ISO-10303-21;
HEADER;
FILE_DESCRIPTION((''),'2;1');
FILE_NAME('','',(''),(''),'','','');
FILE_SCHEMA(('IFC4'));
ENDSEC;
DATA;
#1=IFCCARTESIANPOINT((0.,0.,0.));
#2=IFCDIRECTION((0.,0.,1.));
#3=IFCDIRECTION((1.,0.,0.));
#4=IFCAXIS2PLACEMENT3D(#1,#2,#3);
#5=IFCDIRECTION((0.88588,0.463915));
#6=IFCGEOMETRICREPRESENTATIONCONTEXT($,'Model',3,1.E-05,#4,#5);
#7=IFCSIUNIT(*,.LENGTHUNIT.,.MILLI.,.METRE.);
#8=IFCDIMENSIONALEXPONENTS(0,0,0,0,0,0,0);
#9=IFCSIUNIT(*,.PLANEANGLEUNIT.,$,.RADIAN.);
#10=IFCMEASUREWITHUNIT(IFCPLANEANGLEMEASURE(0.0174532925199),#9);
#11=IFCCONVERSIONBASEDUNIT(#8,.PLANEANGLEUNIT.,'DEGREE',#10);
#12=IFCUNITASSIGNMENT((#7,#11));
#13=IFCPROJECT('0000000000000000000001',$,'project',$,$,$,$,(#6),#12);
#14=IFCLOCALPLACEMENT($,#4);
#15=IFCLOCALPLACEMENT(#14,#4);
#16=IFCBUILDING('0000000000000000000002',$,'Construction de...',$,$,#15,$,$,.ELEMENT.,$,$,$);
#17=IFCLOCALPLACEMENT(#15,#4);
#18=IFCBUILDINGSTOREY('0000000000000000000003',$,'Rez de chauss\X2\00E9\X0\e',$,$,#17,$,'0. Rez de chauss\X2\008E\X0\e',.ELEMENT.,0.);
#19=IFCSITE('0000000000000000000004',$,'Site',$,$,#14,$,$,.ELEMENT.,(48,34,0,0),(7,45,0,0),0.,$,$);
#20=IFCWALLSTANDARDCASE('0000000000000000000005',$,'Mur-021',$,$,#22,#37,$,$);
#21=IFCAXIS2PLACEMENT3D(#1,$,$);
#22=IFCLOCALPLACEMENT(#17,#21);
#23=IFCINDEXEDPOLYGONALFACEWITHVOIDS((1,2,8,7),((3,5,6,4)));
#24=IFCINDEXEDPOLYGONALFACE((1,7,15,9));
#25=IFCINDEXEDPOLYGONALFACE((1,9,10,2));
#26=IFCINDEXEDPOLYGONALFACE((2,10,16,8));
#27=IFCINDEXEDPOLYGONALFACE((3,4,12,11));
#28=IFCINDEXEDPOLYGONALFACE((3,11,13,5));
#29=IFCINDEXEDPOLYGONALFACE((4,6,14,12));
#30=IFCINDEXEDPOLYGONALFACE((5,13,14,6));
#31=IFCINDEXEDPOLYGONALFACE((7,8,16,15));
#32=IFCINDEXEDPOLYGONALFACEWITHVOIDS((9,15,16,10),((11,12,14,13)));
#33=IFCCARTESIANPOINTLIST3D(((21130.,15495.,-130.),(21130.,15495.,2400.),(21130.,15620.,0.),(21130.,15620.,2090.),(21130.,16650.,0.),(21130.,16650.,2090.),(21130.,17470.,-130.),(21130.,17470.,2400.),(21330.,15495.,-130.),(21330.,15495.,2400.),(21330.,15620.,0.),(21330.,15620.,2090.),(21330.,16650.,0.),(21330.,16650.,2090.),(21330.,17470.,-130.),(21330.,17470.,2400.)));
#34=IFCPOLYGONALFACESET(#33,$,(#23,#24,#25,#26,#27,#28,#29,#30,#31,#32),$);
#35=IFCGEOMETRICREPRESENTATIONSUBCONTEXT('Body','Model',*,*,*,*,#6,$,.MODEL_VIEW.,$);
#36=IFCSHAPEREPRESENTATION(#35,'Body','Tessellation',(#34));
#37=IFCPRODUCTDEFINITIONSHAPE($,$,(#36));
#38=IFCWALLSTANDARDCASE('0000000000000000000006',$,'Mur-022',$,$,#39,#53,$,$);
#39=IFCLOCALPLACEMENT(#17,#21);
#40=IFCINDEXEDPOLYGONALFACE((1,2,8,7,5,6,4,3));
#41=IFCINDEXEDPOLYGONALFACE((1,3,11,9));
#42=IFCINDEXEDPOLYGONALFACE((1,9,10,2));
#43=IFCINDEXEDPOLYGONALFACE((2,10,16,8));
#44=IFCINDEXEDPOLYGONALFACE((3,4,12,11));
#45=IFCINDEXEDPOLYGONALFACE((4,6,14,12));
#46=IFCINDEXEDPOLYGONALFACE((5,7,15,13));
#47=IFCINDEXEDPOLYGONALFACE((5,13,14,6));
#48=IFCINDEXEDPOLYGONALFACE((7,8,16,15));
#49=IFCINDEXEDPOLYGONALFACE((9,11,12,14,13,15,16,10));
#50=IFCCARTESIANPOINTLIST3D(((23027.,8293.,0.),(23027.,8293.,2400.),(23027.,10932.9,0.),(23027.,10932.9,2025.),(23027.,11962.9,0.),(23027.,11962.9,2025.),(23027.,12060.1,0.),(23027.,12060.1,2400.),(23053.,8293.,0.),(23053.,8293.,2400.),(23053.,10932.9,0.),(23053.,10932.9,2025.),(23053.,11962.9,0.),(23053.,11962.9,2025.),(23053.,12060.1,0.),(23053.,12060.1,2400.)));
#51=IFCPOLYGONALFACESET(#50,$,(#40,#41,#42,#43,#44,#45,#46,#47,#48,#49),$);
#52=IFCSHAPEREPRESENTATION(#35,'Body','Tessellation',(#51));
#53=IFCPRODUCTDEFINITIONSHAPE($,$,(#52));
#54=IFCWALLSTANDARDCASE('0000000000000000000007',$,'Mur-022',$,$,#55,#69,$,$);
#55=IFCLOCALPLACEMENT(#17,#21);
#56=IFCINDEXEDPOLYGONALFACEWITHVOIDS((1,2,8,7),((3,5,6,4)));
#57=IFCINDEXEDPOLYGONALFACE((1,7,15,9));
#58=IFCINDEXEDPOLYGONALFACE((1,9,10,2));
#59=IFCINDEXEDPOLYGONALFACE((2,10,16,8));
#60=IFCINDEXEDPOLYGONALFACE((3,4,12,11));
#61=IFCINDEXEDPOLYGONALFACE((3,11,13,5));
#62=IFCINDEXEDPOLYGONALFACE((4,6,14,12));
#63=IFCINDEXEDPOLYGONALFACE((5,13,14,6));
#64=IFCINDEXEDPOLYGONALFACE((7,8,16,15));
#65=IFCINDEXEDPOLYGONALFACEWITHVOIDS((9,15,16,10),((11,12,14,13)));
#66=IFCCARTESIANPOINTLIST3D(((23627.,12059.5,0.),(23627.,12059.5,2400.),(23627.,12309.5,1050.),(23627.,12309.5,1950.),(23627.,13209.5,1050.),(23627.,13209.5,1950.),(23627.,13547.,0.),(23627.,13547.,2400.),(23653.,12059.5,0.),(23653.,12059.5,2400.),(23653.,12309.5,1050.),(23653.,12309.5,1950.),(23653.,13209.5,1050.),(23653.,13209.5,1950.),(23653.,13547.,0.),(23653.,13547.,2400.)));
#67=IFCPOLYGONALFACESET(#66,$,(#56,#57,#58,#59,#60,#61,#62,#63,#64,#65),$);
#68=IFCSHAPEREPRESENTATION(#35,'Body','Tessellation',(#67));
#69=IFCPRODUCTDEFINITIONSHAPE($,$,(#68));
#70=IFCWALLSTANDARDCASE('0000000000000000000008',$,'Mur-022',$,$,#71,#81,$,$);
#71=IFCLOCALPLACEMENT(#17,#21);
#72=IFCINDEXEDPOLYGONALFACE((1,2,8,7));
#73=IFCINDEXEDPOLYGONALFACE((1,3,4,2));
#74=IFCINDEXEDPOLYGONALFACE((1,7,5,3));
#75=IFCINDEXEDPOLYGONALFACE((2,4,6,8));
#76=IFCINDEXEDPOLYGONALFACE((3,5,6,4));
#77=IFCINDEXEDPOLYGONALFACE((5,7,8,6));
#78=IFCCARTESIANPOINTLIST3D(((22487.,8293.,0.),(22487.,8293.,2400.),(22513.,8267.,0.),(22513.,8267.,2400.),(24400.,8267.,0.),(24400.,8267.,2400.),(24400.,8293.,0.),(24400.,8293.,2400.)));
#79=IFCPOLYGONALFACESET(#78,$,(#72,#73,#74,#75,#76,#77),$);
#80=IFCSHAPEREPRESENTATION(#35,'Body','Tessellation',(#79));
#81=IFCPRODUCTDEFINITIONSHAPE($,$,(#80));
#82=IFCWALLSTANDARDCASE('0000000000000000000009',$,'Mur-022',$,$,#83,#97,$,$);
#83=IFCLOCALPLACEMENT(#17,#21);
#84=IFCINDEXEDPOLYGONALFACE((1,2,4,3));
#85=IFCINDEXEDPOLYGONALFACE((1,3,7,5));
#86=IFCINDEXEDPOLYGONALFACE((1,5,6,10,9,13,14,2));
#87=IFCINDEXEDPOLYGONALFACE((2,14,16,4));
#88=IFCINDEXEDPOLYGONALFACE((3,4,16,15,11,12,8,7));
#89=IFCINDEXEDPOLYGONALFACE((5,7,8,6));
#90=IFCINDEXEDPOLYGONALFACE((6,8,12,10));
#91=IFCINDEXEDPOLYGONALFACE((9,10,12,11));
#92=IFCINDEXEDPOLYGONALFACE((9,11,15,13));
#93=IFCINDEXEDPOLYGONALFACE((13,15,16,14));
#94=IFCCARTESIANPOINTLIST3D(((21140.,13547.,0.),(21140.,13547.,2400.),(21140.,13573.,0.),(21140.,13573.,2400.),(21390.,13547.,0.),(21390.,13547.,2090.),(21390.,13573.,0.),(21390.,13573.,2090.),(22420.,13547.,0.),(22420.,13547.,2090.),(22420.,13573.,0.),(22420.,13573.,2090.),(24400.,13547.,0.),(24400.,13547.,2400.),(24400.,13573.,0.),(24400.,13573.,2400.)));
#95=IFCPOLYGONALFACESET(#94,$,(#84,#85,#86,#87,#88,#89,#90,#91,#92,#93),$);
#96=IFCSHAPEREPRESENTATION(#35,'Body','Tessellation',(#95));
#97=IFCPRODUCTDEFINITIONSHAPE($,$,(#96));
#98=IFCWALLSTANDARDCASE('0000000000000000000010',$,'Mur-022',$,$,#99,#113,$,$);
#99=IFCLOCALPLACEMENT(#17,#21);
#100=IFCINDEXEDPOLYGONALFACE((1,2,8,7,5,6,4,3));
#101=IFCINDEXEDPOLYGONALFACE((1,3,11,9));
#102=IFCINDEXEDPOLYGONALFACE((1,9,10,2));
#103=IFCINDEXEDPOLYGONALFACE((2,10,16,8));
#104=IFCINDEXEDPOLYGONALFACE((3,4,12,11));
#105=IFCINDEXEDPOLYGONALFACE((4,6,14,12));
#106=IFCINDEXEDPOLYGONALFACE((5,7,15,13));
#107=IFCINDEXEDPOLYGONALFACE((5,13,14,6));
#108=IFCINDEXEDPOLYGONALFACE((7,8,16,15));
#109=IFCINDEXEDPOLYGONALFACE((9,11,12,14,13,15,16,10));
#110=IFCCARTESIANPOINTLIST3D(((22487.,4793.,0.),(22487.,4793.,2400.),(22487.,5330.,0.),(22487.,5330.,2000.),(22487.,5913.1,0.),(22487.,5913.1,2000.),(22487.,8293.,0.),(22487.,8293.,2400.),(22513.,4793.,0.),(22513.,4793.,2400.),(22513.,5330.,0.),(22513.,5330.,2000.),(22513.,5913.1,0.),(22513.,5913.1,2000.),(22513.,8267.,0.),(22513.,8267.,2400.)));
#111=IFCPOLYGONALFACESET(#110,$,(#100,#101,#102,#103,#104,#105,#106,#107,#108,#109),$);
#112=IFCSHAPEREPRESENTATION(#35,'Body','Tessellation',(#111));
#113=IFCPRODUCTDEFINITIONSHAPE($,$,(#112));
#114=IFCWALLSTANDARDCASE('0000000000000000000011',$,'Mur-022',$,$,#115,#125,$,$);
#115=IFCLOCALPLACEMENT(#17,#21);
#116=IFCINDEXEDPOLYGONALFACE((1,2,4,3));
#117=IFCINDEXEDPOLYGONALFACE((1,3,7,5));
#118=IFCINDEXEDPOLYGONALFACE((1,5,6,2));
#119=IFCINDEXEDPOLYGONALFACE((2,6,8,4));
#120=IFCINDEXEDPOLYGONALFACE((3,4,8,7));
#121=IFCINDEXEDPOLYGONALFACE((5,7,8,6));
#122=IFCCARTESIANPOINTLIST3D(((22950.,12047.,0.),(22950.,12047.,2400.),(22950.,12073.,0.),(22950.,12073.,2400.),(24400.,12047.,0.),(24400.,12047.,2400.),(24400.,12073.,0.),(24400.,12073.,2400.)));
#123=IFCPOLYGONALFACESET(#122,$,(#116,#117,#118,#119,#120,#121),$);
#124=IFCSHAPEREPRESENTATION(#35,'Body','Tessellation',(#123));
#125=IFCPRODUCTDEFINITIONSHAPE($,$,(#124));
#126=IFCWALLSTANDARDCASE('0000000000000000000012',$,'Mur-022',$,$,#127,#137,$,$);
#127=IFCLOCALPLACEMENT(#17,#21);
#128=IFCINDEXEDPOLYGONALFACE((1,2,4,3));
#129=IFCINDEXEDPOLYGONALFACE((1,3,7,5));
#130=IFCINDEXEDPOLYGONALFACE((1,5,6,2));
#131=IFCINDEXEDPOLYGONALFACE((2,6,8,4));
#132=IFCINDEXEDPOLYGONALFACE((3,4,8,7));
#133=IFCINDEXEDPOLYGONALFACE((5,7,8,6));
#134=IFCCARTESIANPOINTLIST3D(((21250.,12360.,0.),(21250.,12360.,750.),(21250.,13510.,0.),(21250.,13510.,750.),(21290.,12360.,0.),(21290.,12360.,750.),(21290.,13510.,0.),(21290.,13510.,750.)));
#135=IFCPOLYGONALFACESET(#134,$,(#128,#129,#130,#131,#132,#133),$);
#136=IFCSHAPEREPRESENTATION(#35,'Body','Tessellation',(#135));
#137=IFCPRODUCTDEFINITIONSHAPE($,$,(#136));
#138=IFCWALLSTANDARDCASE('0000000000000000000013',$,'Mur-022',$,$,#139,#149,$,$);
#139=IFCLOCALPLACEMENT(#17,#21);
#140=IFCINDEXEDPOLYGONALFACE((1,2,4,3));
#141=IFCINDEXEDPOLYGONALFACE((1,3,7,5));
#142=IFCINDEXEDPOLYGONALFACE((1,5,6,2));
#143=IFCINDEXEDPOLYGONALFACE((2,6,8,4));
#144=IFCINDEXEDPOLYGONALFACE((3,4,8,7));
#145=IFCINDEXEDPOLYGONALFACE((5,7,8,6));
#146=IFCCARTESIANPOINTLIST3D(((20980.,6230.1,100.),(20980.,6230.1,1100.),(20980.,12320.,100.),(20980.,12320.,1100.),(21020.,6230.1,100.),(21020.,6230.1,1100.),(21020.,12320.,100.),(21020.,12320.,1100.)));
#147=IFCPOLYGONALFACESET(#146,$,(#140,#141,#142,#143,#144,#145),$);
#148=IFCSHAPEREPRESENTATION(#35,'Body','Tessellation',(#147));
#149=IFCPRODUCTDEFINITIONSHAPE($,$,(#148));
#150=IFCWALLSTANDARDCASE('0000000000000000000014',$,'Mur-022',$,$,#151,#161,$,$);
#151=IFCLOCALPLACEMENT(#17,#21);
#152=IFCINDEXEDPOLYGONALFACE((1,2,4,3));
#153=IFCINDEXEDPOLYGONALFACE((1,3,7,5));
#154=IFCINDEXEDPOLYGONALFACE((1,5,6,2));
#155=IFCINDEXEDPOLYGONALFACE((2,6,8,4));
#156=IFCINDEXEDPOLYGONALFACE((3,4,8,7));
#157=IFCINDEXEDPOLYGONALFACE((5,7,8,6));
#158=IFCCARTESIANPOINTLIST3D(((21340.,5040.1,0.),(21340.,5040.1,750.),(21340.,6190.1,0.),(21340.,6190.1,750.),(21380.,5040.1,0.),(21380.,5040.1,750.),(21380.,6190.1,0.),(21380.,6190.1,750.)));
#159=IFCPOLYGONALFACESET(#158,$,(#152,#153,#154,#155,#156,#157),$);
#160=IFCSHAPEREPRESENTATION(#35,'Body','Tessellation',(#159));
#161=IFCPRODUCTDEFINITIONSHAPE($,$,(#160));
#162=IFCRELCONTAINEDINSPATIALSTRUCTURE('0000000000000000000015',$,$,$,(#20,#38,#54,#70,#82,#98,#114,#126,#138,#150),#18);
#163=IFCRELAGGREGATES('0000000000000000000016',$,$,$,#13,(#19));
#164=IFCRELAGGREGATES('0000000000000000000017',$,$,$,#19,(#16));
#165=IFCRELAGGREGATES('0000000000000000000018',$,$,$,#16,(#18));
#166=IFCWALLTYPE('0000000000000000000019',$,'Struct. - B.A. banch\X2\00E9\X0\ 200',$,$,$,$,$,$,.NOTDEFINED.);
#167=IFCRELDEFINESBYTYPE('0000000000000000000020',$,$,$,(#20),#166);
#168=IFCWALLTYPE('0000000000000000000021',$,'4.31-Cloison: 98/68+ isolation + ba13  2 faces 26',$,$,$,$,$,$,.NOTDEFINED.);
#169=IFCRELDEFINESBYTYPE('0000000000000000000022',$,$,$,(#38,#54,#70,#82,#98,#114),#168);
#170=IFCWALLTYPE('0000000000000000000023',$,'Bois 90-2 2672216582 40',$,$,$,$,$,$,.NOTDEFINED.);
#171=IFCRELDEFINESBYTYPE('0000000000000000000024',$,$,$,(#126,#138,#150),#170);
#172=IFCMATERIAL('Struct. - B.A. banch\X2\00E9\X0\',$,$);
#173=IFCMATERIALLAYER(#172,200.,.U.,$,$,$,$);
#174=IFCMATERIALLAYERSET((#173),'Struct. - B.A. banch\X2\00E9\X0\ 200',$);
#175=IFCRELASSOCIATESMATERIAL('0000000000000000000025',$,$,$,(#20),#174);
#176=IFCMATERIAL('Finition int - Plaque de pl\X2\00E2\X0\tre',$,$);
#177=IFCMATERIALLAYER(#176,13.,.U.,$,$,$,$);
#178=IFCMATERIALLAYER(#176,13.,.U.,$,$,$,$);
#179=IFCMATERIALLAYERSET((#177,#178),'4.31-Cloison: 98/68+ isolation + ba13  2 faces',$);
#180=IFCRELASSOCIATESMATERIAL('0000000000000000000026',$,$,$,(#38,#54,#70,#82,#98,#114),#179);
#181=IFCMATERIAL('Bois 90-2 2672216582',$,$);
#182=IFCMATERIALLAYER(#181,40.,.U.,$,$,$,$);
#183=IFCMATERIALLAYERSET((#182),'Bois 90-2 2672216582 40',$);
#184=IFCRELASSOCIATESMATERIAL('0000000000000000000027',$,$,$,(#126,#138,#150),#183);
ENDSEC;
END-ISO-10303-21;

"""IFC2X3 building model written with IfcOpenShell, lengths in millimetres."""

from ifc_helpers import new_model, entity, si_unit, converted_unit, direction, frame, origin_with_axes, origin_2d_with_axis, place, context, subcontext, project, spatial, polyline, rectangle, outline, extrude, material, layer, layer_set, layer_usage, type_object, element, save


model = new_model("IFC2X3")

# Units and contexts
model_context = context("Model", 3, precision=1e-05, world=origin_with_axes(), true_north=direction((0.88588, 0.463915)))
body_context = subcontext(model_context, "Body", "Model", "MODEL_VIEW")
ifc_project = project(units=[si_unit("LENGTHUNIT", "METRE", prefix="MILLI"), converted_unit("PLANEANGLEUNIT", "DEGREE", entity("IfcPlaneAngleMeasure", 0.0174532925199), si_unit("PLANEANGLEUNIT", "RADIAN"), dimensions=[0, 0, 0, 0, 0, 0, 0])], contexts=[model_context])

# Site, building, storey
site_placement = place(None, origin_with_axes())
site = spatial("IfcSite", under=ifc_project, at=site_placement, Name="Site", CompositionType="ELEMENT", RefLatitude=(48, 34, 0, 0), RefLongitude=(7, 45, 0, 0), RefElevation=0.0)
building_placement = place(site_placement, origin_with_axes())
building = spatial("IfcBuilding", under=site, at=building_placement, Name="Construction de...", CompositionType="ELEMENT")
storey_placement = place(building_placement, origin_with_axes())
storey = spatial("IfcBuildingStorey", under=building, at=storey_placement, Name="Rez de chaussée", LongName="0. Rez de chauss\u008ee", CompositionType="ELEMENT", Elevation=0.0)

# Shared definitions
ifc_material_1 = material(Name="Struct. - B.A. banché")
ifc_layer_1 = layer(ifc_material_1, 200.0, ventilated="UNKNOWN")
ifc_layer_set_1 = layer_set([ifc_layer_1], Name="Struct. - B.A. banché 200")
wall_type_1 = type_object("IfcWallType", Name="Struct. - B.A. banché 200", PredefinedType="NOTDEFINED")

# Walls, openings
ifc_layer_usage_1 = layer_usage(ifc_layer_set_1, "AXIS2", "NEGATIVE", 100.0)
wall_1_placement = place(storey_placement, frame((21230.0, 15495.0, -130.0), z_axis=(0.0, 0.0, 1.0), x_axis=(0.0, 1.0, 0.0)))
wall_1 = element("IfcWallStandardCase", 1, at=wall_1_placement, inside=storey, type_object=wall_type_1, material=ifc_layer_usage_1, Name="Mur-021", context=body_context, shape_type="SweptSolid", body=[
    extrude(outline(polyline([(0.0, -100.0), (1975.0, -100.0), (1975.0, 100.0), (0.0, 100.0), (0.0, -100.0)])), origin_with_axes(), (0.0, 0.0, 1.0), 2530.0),
])
opening_1_placement = place(wall_1_placement, frame((640.0, 0.0, 130.0), z_axis=(0.0, 0.0, 1.0), x_axis=(1.0, 0.0, 0.0)))
element("IfcOpeningElement", 2, at=opening_1_placement, cuts=wall_1, context=body_context, shape_type="SweptSolid", body=[
    extrude(rectangle(XDim=1030.0, YDim=2090.0, at=origin_2d_with_axis()), frame((0.0, -200.0, 1045.0), z_axis=(0.0, -1.0, 0.0), x_axis=(-1.0, 0.0, 0.0)), (0.0, 0.0, -1.0), 600.0),
])
ifc_material_2 = material(Name="Finition int - Plaque de plâtre")
ifc_layer_2 = layer(ifc_material_2, 13.0, ventilated="UNKNOWN")
ifc_layer_3 = layer(ifc_material_2, 13.0, ventilated="UNKNOWN")
ifc_layer_set_2 = layer_set([ifc_layer_2, ifc_layer_3], Name="4.31-Cloison: 98/68+ isolation + ba13  2 faces")
ifc_layer_usage_2 = layer_usage(ifc_layer_set_2, "AXIS2", "POSITIVE", -13.0)
wall_type_2 = type_object("IfcWallType", Name="4.31-Cloison: 98/68+ isolation + ba13  2 faces 26", PredefinedType="NOTDEFINED")
wall_2_placement = place(storey_placement, frame((23040.0, 12060.1, 0.0), z_axis=(0.0, 0.0, 1.0), x_axis=(0.0, -1.0, 0.0)))
wall_2 = element("IfcWallStandardCase", 3, at=wall_2_placement, inside=storey, type_object=wall_type_2, material=ifc_layer_usage_2, Name="Mur-022", context=body_context, shape_type="SweptSolid", body=[
    extrude(outline(polyline([(0.0, -13.0), (3767.1, -13.0), (3767.1, 13.0), (0.0, 13.0), (0.0, -13.0)])), origin_with_axes(), (0.0, 0.0, 1.0), 2400.0),
])
opening_2_placement = place(wall_2_placement, frame((612.2, 0.0, 0.0), z_axis=(0.0, 0.0, 1.0), x_axis=(1.0, 0.0, 0.0)))
element("IfcOpeningElement", 4, at=opening_2_placement, cuts=wall_2, context=body_context, shape_type="SweptSolid", body=[
    extrude(rectangle(XDim=1030.0, YDim=2025.0, at=origin_2d_with_axis()), frame((0.0, -26.0, 1012.5), z_axis=(0.0, -1.0, 0.0), x_axis=(-1.0, 0.0, 0.0)), (0.0, 0.0, -1.0), 78.0),
])
ifc_layer_usage_3 = layer_usage(ifc_layer_set_2, "AXIS2", "POSITIVE", -13.0)
wall_3_placement = place(storey_placement, frame((23640.0, 13560.0, 0.0), z_axis=(0.0, 0.0, 1.0), x_axis=(0.0, -1.0, 0.0)))
wall_3 = element("IfcWallStandardCase", 5, at=wall_3_placement, inside=storey, type_object=wall_type_2, material=ifc_layer_usage_3, Name="Mur-022", context=body_context, shape_type="SweptSolid", body=[
    extrude(outline(polyline([(13.0, -13.0), (1500.5, -13.0), (1500.5, 13.0), (13.0, 13.0), (13.0, -13.0)])), origin_with_axes(), (0.0, 0.0, 1.0), 2400.0),
])
opening_3_placement = place(wall_3_placement, frame((800.5, 0.0, 1050.0), z_axis=(0.0, 0.0, 1.0), x_axis=(1.0, 0.0, 0.0)))
element("IfcOpeningElement", 6, at=opening_3_placement, cuts=wall_3, context=body_context, shape_type="SweptSolid", body=[
    extrude(rectangle(XDim=900.0, YDim=900.0, at=origin_2d_with_axis()), frame((0.0, -13.0, 450.0), z_axis=(0.0, 1.0, 0.0), x_axis=(1.0, 0.0, 0.0)), (0.0, 0.0, -1.0), 26.0),
    extrude(rectangle(XDim=900.0, YDim=900.0, at=origin_2d_with_axis()), frame((0.0, -13.0, 450.0), z_axis=(0.0, -1.0, 0.0), x_axis=(1.0, 0.0, 0.0)), (0.0, 0.0, -1.0), 26.0),
])

# Wall
ifc_layer_usage_4 = layer_usage(ifc_layer_set_2, "AXIS2", "POSITIVE", -13.0)
wall_4_placement = place(storey_placement, frame((24400.0, 8280.0, 0.0), z_axis=(0.0, 0.0, 1.0), x_axis=(-1.0, 0.0, 0.0)))
element("IfcWallStandardCase", 7, at=wall_4_placement, inside=storey, type_object=wall_type_2, material=ifc_layer_usage_4, Name="Mur-022", context=body_context, shape_type="SweptSolid", body=[
    extrude(outline(polyline([(0.0, -13.0), (1913.0, -13.0), (1887.0, 13.0), (0.0, 13.0), (0.0, -13.0)])), origin_with_axes(), (0.0, 0.0, 1.0), 2400.0),
])

# Walls, openings
ifc_layer_usage_5 = layer_usage(ifc_layer_set_2, "AXIS2", "POSITIVE", -13.0)
wall_5_placement = place(storey_placement, frame((24400.0, 13560.0, 0.0), z_axis=(0.0, 0.0, 1.0), x_axis=(-1.0, 0.0, 0.0)))
wall_5 = element("IfcWallStandardCase", 8, at=wall_5_placement, inside=storey, type_object=wall_type_2, material=ifc_layer_usage_5, Name="Mur-022", context=body_context, shape_type="SweptSolid", body=[
    extrude(outline(polyline([(0.0, -13.0), (3260.0, -13.0), (3260.0, 13.0), (0.0, 13.0), (0.0, -13.0)])), origin_with_axes(), (0.0, 0.0, 1.0), 2400.0),
])
opening_4_placement = place(wall_5_placement, frame((2495.0, 0.0, 0.0), z_axis=(0.0, 0.0, 1.0), x_axis=(1.0, 0.0, 0.0)))
element("IfcOpeningElement", 9, at=opening_4_placement, cuts=wall_5, context=body_context, shape_type="SweptSolid", body=[
    extrude(rectangle(XDim=1030.0, YDim=2090.0, at=origin_2d_with_axis()), frame((0.0, -26.0, 1045.0), z_axis=(0.0, 1.0, 0.0), x_axis=(1.0, 0.0, 0.0)), (0.0, 0.0, 1.0), 78.0),
])
ifc_layer_usage_6 = layer_usage(ifc_layer_set_2, "AXIS2", "POSITIVE", -13.0)
wall_6_placement = place(storey_placement, frame((22500.0, 8280.0, 0.0), z_axis=(0.0, 0.0, 1.0), x_axis=(0.0, -1.0, 0.0)))
wall_6 = element("IfcWallStandardCase", 10, at=wall_6_placement, inside=storey, type_object=wall_type_2, material=ifc_layer_usage_6, Name="Mur-022", context=body_context, shape_type="SweptSolid", body=[
    extrude(outline(polyline([(-13.0, -13.0), (3487.0, -13.0), (3487.0, 13.0), (13.0, 13.0), (-13.0, -13.0)])), origin_with_axes(), (0.0, 0.0, 1.0), 2400.0),
])
opening_5_placement = place(wall_6_placement, frame((2658.4, 0.0, 0.0), z_axis=(0.0, 0.0, 1.0), x_axis=(1.0, 0.0, 0.0)))
element("IfcOpeningElement", 11, at=opening_5_placement, cuts=wall_6, context=body_context, shape_type="SweptSolid", body=[
    extrude(rectangle(XDim=583.1, YDim=2000.0, at=origin_2d_with_axis()), frame((0.0, -13.0, 1000.0), z_axis=(0.0, 1.0, 0.0), x_axis=(1.0, 0.0, 0.0)), (0.0, 0.0, -1.0), 26.0),
    extrude(rectangle(XDim=583.1, YDim=2000.0, at=origin_2d_with_axis()), frame((0.0, -13.0, 1000.0), z_axis=(0.0, -1.0, 0.0), x_axis=(1.0, 0.0, 0.0)), (0.0, 0.0, -1.0), 26.0),
])

# Walls
ifc_layer_usage_7 = layer_usage(ifc_layer_set_2, "AXIS2", "POSITIVE", -13.0)
wall_7_placement = place(storey_placement, frame((24400.0, 12060.0, 0.0), z_axis=(0.0, 0.0, 1.0), x_axis=(-1.0, 0.0, 0.0)))
element("IfcWallStandardCase", 12, at=wall_7_placement, inside=storey, type_object=wall_type_2, material=ifc_layer_usage_7, Name="Mur-022", context=body_context, shape_type="SweptSolid", body=[
    extrude(outline(polyline([(0.0, -13.0), (1450.0, -13.0), (1450.0, 13.0), (0.0, 13.0), (0.0, -13.0)])), origin_with_axes(), (0.0, 0.0, 1.0), 2400.0),
])
ifc_material_3 = material(Name="Bois 90-2 2672216582")
ifc_layer_4 = layer(ifc_material_3, 40.0, ventilated="UNKNOWN")
ifc_layer_set_3 = layer_set([ifc_layer_4], Name="Bois 90-2 2672216582 40")
ifc_layer_usage_8 = layer_usage(ifc_layer_set_3, "AXIS2", "POSITIVE", -20.0)
wall_type_3 = type_object("IfcWallType", Name="Bois 90-2 2672216582 40", PredefinedType="NOTDEFINED")
wall_8_placement = place(storey_placement, frame((21270.0, 13510.0, 0.0), z_axis=(0.0, 0.0, 1.0), x_axis=(0.0, -1.0, 0.0)))
element("IfcWallStandardCase", 13, at=wall_8_placement, inside=storey, type_object=wall_type_3, material=ifc_layer_usage_8, Name="Mur-022", context=body_context, shape_type="SweptSolid", body=[
    extrude(outline(polyline([(0.0, -20.0), (1150.0, -20.0), (1150.0, 20.0), (0.0, 20.0), (0.0, -20.0)])), origin_with_axes(), (0.0, 0.0, 1.0), 750.0),
])
ifc_layer_usage_9 = layer_usage(ifc_layer_set_3, "AXIS2", "POSITIVE", -20.0)
wall_9_placement = place(storey_placement, frame((21000.0, 12340.0, 100.0), z_axis=(0.0, 0.0, 1.0), x_axis=(0.0, -1.0, 0.0)))
element("IfcWallStandardCase", 14, at=wall_9_placement, inside=storey, type_object=wall_type_3, material=ifc_layer_usage_9, Name="Mur-022", context=body_context, shape_type="SweptSolid", body=[
    extrude(outline(polyline([(20.0, -20.0), (6109.9, -20.0), (6109.9, 20.0), (20.0, 20.0), (20.0, -20.0)])), origin_with_axes(), (0.0, 0.0, 1.0), 1000.0),
])
ifc_layer_usage_10 = layer_usage(ifc_layer_set_3, "AXIS2", "POSITIVE", -20.0)
wall_10_placement = place(storey_placement, frame((21360.0, 6190.1, 0.0), z_axis=(0.0, 0.0, 1.0), x_axis=(0.0, -1.0, 0.0)))
element("IfcWallStandardCase", 15, at=wall_10_placement, inside=storey, type_object=wall_type_3, material=ifc_layer_usage_10, Name="Mur-022", context=body_context, shape_type="SweptSolid", body=[
    extrude(outline(polyline([(0.0, -20.0), (1150.0, -20.0), (1150.0, 20.0), (0.0, 20.0), (0.0, -20.0)])), origin_with_axes(), (0.0, 0.0, 1.0), 750.0),
])

save(model, "model.ifc")
